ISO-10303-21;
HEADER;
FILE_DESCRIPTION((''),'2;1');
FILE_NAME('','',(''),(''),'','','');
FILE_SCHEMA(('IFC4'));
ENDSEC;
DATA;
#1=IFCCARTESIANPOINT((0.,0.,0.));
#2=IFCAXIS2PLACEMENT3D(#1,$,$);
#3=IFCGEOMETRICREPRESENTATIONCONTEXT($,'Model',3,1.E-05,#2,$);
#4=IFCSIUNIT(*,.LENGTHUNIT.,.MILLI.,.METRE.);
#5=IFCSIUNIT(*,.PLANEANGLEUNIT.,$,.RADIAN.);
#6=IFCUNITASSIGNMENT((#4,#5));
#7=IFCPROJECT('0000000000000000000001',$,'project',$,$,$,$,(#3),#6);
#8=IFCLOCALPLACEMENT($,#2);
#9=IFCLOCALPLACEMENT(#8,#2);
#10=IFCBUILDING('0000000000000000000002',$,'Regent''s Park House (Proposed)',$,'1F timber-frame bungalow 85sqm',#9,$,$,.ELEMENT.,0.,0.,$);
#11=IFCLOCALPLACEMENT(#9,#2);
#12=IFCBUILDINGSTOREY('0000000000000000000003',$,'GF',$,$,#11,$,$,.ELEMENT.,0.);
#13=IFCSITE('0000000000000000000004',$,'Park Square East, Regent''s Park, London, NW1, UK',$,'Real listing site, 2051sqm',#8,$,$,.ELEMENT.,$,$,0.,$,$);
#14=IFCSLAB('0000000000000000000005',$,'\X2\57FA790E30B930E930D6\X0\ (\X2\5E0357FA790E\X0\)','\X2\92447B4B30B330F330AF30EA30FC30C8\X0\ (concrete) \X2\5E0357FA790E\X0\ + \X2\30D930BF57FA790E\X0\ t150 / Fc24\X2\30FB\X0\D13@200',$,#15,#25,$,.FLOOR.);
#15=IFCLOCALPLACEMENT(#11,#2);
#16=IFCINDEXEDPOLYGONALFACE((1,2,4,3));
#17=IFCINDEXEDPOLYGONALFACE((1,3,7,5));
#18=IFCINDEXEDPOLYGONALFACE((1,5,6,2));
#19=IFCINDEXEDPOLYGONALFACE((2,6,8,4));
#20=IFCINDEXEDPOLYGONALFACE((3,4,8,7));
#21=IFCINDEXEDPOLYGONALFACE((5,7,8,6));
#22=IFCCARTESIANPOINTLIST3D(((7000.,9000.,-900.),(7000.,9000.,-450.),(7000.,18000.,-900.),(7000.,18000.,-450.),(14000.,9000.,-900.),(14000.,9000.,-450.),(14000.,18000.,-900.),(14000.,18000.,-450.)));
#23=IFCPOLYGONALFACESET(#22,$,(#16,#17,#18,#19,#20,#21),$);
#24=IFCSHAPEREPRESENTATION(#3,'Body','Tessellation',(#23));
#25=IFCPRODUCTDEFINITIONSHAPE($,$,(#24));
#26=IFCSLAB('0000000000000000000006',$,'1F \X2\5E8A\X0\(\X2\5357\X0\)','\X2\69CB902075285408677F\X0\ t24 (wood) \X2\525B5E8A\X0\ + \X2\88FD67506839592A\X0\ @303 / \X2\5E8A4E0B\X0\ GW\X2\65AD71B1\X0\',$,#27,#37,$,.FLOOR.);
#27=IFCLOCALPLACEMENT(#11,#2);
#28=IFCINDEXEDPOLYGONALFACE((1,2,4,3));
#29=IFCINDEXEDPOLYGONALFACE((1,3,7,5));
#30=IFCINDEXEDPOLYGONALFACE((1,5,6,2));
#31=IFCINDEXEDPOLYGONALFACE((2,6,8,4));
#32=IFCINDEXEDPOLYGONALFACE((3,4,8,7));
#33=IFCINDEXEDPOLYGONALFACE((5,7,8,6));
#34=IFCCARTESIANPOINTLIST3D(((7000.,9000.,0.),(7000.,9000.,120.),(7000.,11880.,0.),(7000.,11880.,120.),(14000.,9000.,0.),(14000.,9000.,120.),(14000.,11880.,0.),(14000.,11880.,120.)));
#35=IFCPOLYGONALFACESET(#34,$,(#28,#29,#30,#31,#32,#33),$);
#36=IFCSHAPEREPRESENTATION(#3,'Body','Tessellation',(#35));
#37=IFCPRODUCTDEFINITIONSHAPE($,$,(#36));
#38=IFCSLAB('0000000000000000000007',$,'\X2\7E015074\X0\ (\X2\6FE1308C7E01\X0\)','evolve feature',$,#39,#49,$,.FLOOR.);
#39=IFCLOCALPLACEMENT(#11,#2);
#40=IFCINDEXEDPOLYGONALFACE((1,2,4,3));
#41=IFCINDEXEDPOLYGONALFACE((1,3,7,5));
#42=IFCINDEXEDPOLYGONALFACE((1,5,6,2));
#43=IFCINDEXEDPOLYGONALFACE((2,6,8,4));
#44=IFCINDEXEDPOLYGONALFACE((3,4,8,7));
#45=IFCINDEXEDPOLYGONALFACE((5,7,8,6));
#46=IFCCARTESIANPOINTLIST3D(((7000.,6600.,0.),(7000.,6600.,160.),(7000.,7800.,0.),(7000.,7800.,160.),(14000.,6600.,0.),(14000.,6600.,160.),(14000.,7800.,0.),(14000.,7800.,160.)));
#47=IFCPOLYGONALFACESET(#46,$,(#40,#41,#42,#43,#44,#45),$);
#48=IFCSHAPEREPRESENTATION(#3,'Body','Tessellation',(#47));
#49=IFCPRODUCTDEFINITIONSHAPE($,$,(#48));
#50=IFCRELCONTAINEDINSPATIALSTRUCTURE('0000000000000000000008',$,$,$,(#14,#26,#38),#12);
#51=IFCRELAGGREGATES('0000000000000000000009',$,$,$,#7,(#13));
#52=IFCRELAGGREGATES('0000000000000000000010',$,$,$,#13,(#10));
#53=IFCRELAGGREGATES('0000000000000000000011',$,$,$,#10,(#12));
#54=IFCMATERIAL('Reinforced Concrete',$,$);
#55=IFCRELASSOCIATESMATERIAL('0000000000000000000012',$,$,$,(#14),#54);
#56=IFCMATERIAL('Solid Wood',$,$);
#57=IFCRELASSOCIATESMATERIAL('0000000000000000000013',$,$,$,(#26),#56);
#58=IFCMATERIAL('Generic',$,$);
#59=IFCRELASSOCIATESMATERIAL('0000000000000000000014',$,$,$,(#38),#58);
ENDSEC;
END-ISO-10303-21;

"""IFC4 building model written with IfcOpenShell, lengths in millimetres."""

from ifc_helpers import new_model, si_unit, frame, frame_2d, origin, place, context, project, spatial, rectangle, extrude, material, element, save


model = new_model("IFC4")

# Units and contexts
model_context = context("Model", 3, precision=1e-05, world=origin())
ifc_project = project(units=[si_unit("LENGTHUNIT", "METRE", prefix="MILLI"), si_unit("PLANEANGLEUNIT", "RADIAN")], contexts=[model_context])

# Site, building, storey
site_placement = place(None, origin())
site = spatial("IfcSite", under=ifc_project, at=site_placement, Name="Park Square East, Regent's Park, London, NW1, UK", ObjectType="Real listing site, 2051sqm", CompositionType="ELEMENT", RefElevation=0.0)
building_placement = place(site_placement, origin())
building = spatial("IfcBuilding", under=site, at=building_placement, Name="Regent's Park House (Proposed)", ObjectType="1F timber-frame bungalow 85sqm", CompositionType="ELEMENT", ElevationOfRefHeight=0.0, ElevationOfTerrain=0.0)
storey_placement = place(building_placement, origin())
storey = spatial("IfcBuildingStorey", under=building, at=storey_placement, Name="GF", CompositionType="ELEMENT", Elevation=0.0)

# Slabs
ifc_material_1 = material(Name="Reinforced Concrete")
slab_1_placement = place(storey_placement, frame((3500.0, 4500.0, -450.0)))
element("IfcSlab", 1, at=slab_1_placement, inside=storey, material=ifc_material_1, Name="基礎スラブ (布基礎)", Description="鉄筋コンクリート (concrete) 布基礎 + ベタ基礎 t150 / Fc24・D13@200", PredefinedType="FLOOR", context=model_context, shape_type="SweptSolid", body=[
    extrude(rectangle(XDim=7000.0, YDim=9000.0, at=frame_2d((3500.0, 4500.0))), frame((3500.0, 4500.0, -450.0)), (0.0, 0.0, 1.0), 450.0),
])
ifc_material_2 = material(Name="Solid Wood")
slab_2_placement = place(storey_placement, frame((3500.0, 4500.0, 0.0)))
element("IfcSlab", 2, at=slab_2_placement, inside=storey, material=ifc_material_2, Name="1F 床(南)", Description="構造用合板 t24 (wood) 剛床 + 製材根太 @303 / 床下 GW断熱", PredefinedType="FLOOR", context=model_context, shape_type="SweptSolid", body=[
    extrude(rectangle(XDim=7000.0, YDim=2880.0, at=frame_2d((3500.0, 1440.0))), frame((3500.0, 4500.0, 0.0)), (0.0, 0.0, 1.0), 120.0),
])
ifc_material_3 = material(Name="Generic")
slab_3_placement = place(storey_placement, frame((3500.0, 3300.0, 0.0)))
element("IfcSlab", 3, at=slab_3_placement, inside=storey, material=ifc_material_3, Name="縁側 (濡れ縁)", Description="evolve feature", PredefinedType="FLOOR", context=model_context, shape_type="SweptSolid", body=[
    extrude(rectangle(XDim=7000.0, YDim=1200.0, at=frame_2d((3500.0, 600.0))), frame((3500.0, 3300.0, 0.0)), (0.0, 0.0, 1.0), 160.0),
])

save(model, "model.ifc")
